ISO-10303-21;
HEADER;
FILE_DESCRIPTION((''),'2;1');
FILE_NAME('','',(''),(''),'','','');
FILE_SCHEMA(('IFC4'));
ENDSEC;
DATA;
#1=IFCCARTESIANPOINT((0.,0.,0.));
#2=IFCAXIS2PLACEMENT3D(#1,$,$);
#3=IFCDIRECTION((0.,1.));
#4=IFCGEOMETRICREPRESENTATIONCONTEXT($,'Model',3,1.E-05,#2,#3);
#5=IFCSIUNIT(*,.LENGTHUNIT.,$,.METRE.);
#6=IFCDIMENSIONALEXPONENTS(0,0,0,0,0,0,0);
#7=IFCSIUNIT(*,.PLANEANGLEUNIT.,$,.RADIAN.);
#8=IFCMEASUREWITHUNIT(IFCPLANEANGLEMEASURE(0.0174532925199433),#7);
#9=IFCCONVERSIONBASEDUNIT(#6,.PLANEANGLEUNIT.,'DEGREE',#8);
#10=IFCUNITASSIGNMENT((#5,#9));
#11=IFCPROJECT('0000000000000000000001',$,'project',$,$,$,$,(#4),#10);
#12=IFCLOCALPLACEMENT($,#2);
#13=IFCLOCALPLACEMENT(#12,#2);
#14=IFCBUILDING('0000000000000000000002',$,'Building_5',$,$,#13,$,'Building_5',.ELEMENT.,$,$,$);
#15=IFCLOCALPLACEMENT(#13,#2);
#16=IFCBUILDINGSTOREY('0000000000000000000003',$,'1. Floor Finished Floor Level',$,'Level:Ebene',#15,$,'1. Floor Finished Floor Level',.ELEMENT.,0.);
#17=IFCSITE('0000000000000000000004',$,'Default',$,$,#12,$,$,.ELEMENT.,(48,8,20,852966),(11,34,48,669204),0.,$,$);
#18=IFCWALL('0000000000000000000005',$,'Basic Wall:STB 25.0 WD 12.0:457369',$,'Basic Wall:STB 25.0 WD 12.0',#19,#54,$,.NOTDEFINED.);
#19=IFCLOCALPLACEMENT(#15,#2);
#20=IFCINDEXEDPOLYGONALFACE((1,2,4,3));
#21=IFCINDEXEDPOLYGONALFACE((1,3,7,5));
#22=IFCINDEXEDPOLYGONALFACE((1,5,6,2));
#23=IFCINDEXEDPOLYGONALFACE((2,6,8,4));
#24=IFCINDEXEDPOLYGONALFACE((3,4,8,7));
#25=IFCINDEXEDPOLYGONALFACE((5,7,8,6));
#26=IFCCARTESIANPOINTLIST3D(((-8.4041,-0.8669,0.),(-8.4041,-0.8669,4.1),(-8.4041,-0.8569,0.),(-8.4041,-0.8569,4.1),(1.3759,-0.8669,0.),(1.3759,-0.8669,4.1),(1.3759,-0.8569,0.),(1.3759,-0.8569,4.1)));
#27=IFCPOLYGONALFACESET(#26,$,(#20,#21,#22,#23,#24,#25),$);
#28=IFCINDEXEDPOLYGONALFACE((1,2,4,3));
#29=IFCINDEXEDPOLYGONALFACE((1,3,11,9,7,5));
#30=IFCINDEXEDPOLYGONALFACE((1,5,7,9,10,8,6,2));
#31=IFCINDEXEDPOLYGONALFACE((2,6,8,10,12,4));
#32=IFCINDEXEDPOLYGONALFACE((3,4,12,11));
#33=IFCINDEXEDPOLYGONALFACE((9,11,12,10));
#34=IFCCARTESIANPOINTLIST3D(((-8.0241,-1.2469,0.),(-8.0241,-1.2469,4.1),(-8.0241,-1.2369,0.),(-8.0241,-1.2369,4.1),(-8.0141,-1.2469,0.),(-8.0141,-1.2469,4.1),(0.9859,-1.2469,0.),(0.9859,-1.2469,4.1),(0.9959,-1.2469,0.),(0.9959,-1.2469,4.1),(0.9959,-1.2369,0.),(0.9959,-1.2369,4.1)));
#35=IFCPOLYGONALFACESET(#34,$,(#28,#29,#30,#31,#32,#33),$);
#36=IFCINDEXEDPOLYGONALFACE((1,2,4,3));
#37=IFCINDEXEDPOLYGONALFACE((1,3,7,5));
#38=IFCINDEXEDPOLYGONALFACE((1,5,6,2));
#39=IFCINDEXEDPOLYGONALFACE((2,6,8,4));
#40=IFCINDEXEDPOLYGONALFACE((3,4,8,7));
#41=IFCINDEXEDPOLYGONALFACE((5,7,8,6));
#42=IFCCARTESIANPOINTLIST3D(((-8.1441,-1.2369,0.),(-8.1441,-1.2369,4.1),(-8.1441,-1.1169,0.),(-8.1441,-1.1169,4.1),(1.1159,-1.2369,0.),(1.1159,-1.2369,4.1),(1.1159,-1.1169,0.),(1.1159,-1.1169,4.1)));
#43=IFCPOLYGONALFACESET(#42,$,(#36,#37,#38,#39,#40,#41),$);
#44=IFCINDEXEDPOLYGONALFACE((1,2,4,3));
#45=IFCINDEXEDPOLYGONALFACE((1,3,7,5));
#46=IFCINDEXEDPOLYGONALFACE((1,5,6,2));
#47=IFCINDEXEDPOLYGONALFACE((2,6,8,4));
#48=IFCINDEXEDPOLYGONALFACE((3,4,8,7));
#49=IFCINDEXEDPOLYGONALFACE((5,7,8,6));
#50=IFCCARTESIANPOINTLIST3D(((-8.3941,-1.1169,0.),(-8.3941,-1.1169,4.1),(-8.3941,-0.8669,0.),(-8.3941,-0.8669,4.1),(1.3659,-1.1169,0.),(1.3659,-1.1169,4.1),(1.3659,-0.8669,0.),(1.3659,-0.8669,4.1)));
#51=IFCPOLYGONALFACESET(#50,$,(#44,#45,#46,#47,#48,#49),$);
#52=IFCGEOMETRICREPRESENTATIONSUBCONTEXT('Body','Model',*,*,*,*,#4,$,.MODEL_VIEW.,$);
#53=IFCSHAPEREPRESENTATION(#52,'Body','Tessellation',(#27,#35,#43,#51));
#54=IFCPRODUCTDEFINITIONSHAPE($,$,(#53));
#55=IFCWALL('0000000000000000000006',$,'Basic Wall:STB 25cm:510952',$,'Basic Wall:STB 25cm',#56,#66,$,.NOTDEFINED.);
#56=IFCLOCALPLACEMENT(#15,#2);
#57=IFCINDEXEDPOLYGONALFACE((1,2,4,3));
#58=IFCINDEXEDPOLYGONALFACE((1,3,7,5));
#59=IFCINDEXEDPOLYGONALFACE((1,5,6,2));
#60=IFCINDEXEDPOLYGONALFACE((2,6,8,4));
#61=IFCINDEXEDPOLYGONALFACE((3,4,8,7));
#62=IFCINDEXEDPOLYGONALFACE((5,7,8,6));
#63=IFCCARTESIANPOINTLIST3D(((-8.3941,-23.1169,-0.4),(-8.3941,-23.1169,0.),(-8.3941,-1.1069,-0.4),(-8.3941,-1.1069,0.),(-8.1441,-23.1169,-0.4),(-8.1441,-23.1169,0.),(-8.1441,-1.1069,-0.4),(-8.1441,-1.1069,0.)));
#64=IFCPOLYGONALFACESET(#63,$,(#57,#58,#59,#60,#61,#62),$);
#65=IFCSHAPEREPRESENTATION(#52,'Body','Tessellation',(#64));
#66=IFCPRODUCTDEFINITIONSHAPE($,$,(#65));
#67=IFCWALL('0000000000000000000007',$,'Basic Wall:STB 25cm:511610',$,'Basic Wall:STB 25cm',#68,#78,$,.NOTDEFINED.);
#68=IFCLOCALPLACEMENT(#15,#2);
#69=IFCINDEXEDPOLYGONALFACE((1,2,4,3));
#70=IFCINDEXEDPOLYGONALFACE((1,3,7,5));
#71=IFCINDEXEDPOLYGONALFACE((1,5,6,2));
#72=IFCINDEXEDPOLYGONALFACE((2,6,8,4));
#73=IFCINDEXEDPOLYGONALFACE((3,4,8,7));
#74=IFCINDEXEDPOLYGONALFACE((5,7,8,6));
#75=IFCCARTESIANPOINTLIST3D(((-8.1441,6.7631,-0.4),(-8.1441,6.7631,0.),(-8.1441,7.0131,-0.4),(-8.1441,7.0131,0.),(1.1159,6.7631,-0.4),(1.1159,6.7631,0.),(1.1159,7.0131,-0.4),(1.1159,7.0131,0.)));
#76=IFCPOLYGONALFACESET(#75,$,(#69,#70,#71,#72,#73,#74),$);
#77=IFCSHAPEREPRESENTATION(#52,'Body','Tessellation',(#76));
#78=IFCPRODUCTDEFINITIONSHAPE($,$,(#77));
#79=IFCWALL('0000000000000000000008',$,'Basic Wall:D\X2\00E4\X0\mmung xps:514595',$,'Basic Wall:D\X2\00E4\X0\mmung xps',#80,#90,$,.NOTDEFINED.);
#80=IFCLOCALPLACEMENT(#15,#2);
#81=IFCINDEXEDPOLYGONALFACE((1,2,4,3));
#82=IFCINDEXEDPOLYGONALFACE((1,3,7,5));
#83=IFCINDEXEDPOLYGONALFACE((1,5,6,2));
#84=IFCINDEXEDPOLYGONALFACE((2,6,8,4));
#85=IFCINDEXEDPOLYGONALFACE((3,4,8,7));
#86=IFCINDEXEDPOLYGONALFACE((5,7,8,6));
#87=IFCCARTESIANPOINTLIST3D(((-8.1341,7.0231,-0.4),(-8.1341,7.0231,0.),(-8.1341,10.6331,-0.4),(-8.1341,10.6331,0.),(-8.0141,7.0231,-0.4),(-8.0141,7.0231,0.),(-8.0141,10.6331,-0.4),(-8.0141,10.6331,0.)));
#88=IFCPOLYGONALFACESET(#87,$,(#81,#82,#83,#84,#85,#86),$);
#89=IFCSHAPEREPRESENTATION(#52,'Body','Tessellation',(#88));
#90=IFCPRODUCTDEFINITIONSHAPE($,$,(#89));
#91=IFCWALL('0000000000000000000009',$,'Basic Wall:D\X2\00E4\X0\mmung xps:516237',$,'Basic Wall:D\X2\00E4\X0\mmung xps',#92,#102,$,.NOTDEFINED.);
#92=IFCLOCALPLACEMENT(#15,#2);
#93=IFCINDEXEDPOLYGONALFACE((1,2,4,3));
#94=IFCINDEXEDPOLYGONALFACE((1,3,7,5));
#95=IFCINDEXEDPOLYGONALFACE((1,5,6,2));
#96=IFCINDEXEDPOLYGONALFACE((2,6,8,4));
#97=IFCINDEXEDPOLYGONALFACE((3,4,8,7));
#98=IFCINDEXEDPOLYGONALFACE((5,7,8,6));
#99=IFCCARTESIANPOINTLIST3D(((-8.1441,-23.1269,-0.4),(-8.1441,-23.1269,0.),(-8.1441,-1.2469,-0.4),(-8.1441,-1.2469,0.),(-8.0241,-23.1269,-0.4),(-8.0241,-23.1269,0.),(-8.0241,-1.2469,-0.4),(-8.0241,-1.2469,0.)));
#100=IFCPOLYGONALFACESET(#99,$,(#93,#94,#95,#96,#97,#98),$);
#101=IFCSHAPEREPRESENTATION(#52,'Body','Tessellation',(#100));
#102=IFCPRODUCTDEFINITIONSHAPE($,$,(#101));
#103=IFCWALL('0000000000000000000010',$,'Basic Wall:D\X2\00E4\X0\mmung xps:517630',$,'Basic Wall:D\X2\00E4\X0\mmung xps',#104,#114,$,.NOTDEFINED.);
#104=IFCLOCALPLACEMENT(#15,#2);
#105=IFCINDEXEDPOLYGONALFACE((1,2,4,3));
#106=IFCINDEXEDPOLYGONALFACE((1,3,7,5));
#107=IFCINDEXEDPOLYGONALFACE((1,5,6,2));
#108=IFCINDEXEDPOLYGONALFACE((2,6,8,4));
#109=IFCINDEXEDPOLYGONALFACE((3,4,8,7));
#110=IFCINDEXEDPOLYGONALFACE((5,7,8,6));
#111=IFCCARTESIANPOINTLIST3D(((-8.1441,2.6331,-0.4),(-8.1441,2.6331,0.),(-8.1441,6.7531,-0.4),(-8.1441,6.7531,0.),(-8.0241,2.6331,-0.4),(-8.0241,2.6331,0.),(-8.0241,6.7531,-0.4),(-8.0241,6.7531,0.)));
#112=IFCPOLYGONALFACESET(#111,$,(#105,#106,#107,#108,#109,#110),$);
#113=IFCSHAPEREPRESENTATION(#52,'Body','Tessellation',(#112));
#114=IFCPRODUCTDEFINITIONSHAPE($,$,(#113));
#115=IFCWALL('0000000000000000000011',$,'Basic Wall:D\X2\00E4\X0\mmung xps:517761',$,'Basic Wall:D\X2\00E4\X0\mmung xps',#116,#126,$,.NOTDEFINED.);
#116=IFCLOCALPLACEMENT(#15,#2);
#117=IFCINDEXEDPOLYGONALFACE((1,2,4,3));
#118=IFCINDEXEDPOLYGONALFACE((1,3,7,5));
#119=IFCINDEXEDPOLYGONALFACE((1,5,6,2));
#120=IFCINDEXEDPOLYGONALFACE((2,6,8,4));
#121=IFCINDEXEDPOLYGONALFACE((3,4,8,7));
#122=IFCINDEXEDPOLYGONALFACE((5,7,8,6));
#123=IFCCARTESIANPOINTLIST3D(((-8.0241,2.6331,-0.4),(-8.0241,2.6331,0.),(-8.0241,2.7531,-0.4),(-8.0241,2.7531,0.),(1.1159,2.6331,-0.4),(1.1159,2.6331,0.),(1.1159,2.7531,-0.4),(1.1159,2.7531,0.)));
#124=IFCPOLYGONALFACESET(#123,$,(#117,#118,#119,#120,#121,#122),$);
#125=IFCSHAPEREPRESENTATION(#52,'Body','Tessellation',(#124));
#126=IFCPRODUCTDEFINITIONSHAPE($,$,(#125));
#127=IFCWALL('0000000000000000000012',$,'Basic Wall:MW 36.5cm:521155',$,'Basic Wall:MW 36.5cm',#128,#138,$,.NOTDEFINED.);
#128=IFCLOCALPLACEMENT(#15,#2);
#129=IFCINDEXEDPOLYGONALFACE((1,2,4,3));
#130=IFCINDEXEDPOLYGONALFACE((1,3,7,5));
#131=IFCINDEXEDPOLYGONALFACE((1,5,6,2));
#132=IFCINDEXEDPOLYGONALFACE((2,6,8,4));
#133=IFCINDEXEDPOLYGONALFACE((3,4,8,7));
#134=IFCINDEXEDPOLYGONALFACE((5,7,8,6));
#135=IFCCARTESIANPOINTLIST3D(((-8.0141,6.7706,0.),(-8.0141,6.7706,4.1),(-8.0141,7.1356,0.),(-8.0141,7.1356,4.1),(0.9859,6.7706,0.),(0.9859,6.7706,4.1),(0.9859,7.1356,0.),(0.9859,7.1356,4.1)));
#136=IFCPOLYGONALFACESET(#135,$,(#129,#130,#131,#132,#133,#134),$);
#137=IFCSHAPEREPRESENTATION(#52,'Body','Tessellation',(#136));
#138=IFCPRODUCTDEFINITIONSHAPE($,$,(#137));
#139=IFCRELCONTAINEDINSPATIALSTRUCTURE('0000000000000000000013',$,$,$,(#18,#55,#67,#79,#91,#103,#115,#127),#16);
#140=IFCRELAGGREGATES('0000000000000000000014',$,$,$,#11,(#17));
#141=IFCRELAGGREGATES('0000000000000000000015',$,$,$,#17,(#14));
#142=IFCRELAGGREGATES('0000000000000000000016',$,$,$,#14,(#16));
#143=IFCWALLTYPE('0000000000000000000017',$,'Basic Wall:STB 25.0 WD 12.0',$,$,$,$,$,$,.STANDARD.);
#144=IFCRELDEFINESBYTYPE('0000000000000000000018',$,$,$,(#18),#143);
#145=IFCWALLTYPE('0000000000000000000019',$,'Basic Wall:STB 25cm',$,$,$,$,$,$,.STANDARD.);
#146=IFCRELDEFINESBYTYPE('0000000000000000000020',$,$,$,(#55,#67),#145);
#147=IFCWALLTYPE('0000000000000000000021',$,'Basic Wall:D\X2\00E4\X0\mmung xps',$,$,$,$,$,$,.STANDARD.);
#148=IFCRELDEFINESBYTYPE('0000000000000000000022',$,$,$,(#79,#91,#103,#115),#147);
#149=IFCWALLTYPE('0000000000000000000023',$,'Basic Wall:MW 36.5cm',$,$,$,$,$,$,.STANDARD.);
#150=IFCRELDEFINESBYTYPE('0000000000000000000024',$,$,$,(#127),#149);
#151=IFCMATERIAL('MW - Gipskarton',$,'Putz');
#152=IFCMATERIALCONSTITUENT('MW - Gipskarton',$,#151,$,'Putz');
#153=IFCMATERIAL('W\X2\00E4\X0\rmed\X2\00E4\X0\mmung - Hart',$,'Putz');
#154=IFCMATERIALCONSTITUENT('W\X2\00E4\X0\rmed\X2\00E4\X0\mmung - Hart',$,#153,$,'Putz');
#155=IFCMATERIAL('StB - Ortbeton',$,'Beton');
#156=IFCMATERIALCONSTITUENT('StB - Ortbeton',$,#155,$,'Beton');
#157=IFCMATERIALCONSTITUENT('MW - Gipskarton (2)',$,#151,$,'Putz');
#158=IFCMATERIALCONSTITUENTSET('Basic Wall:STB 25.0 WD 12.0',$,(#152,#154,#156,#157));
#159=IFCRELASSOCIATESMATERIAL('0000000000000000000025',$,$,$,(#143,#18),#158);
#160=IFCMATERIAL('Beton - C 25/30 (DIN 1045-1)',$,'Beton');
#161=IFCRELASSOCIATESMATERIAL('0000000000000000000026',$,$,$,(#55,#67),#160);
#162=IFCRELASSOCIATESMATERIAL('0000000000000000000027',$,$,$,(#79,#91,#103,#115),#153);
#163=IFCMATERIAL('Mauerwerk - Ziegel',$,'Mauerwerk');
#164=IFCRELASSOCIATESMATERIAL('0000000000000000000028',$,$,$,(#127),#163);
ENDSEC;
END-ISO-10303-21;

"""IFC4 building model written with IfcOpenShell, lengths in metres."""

from ifc_helpers import new_model, entity, si_unit, converted_unit, direction, frame, origin, place, context, subcontext, project, spatial, indexed_curve, outline, extrude, material, constituent, constituent_set, type_object, element, save


model = new_model("IFC4")

# Units and contexts
model_context = context("Model", 3, precision=1e-05, world=origin(), true_north=direction((0.0, 1.0)))
body_context = subcontext(model_context, "Body", "Model", "MODEL_VIEW")
ifc_project = project(units=[si_unit("LENGTHUNIT", "METRE"), converted_unit("PLANEANGLEUNIT", "DEGREE", entity("IfcPlaneAngleMeasure", 0.0174532925199433), si_unit("PLANEANGLEUNIT", "RADIAN"), dimensions=[0, 0, 0, 0, 0, 0, 0])], contexts=[model_context])

# Site, building, storey
site_placement = place(None, origin())
site = spatial("IfcSite", under=ifc_project, at=site_placement, Name="Default", CompositionType="ELEMENT", RefLatitude=(48, 8, 20, 852966), RefLongitude=(11, 34, 48, 669204), RefElevation=0.0)
building_placement = place(site_placement, origin())
building = spatial("IfcBuilding", under=site, at=building_placement, Name="Building_5", LongName="Building_5", CompositionType="ELEMENT")
storey_placement = place(building_placement, origin())
storey = spatial("IfcBuildingStorey", under=building, at=storey_placement, Name="1. Floor Finished Floor Level", ObjectType="Level:Ebene", LongName="1. Floor Finished Floor Level", CompositionType="ELEMENT", Elevation=0.0)

# Shared definitions
ifc_material_1 = material(Name="Mauerwerk - Ziegel", Category="Mauerwerk")

# Wall
ifc_material_2 = material(Name="MW - Gipskarton", Category="Putz")
ifc_constituent_1 = constituent(ifc_material_2, Name="MW - Gipskarton", Category="Putz")
ifc_material_3 = material(Name="Wärmedämmung - Hart", Category="Putz")
ifc_constituent_2 = constituent(ifc_material_3, Name="Wärmedämmung - Hart", Category="Putz")
ifc_material_4 = material(Name="StB - Ortbeton", Category="Beton")
ifc_constituent_3 = constituent(ifc_material_4, Name="StB - Ortbeton", Category="Beton")
ifc_constituent_4 = constituent(ifc_material_2, Name="MW - Gipskarton (2)", Category="Putz")
ifc_constituent_set_1 = constituent_set(constituents=[ifc_constituent_1, ifc_constituent_2, ifc_constituent_3, ifc_constituent_4], Name="Basic Wall:STB 25.0 WD 12.0")
wall_type_1 = type_object("IfcWallType", Name="Basic Wall:STB 25.0 WD 12.0", PredefinedType="STANDARD", material=ifc_constituent_set_1)
wall_1_placement = place(storey_placement, frame((-8.4041, -1.0519, 0.0)))
element("IfcWall", 1, at=wall_1_placement, inside=storey, type_object=wall_type_1, material=ifc_constituent_set_1, Name="Basic Wall:STB 25.0 WD 12.0:457369", ObjectType="Basic Wall:STB 25.0 WD 12.0", PredefinedType="NOTDEFINED", context=body_context, shape_type="SweptSolid", body=[
    extrude(outline(indexed_curve([(-0.005, -4.89), (0.005, -4.89), (0.005, 4.89), (-0.005, 4.89), (-0.005, -4.89)], self_intersect=False)), frame((4.89, 0.19, 0.0), z_axis=(0.0, 0.0, 1.0), x_axis=(0.0, -1.0, 0.0)), (0.0, 0.0, 1.0), 4.1),
    extrude(outline(indexed_curve([(-4.5, -0.0033), (4.5, -0.0033), (4.51, -0.0033), (4.51, 0.0067), (-4.51, 0.0067), (-4.51, -0.0033), (-4.5, -0.0033)], self_intersect=False)), frame((4.89, -0.1917, 0.0)), (0.0, 0.0, 1.0), 4.1),
    extrude(outline(indexed_curve([(-4.63, -0.06), (4.63, -0.06), (4.63, 0.06), (-4.63, 0.06), (-4.63, -0.06)], self_intersect=False)), frame((4.89, -0.125, 0.0)), (0.0, 0.0, 1.0), 4.1),
    extrude(outline(indexed_curve([(-4.88, -0.125), (4.88, -0.125), (4.88, 0.125), (-4.88, 0.125), (-4.88, -0.125)], self_intersect=False)), frame((4.89, 0.06, 0.0)), (0.0, 0.0, 1.0), 4.1),
])

# Walls
ifc_material_5 = material(Name="Beton - C 25/30 (DIN 1045-1)", Category="Beton")
wall_type_2 = type_object("IfcWallType", Name="Basic Wall:STB 25cm", PredefinedType="STANDARD")
wall_2_placement = place(storey_placement, frame((-8.2691, -1.1069, -0.4), z_axis=(0.0, 0.0, 1.0), x_axis=(0.0, -1.0, 0.0)))
element("IfcWall", 2, at=wall_2_placement, inside=storey, type_object=wall_type_2, material=ifc_material_5, Name="Basic Wall:STB 25cm:510952", ObjectType="Basic Wall:STB 25cm", PredefinedType="NOTDEFINED", context=body_context, shape_type="SweptSolid", body=[
    extrude(outline(indexed_curve([(22.01, 0.125), (0.0, 0.125), (0.0, -0.125), (22.01, -0.125), (22.01, 0.125)], self_intersect=False)), origin(), (0.0, 0.0, 1.0), 0.4),
])
wall_3_placement = place(storey_placement, frame((-8.1441, 6.8881, -0.4)))
element("IfcWall", 3, at=wall_3_placement, inside=storey, type_object=wall_type_2, material=ifc_material_5, Name="Basic Wall:STB 25cm:511610", ObjectType="Basic Wall:STB 25cm", PredefinedType="NOTDEFINED", context=body_context, shape_type="SweptSolid", body=[
    extrude(outline(indexed_curve([(9.26, 0.125), (0.0, 0.125), (0.0, -0.125), (9.26, -0.125), (9.26, 0.125)], self_intersect=False)), origin(), (0.0, 0.0, 1.0), 0.4),
])
wall_type_3 = type_object("IfcWallType", Name="Basic Wall:Dämmung xps", PredefinedType="STANDARD")
wall_4_placement = place(storey_placement, frame((-8.0741, 10.6331, -0.4), z_axis=(0.0, 0.0, 1.0), x_axis=(0.0, -1.0, 0.0)))
element("IfcWall", 4, at=wall_4_placement, inside=storey, type_object=wall_type_3, material=ifc_material_3, Name="Basic Wall:Dämmung xps:514595", ObjectType="Basic Wall:Dämmung xps", PredefinedType="NOTDEFINED", context=body_context, shape_type="SweptSolid", body=[
    extrude(outline(indexed_curve([(3.61, 0.06), (0.0, 0.06), (0.0, -0.06), (3.61, -0.06), (3.61, 0.06)], self_intersect=False)), origin(), (0.0, 0.0, 1.0), 0.4),
])
wall_5_placement = place(storey_placement, frame((-8.0841, -1.2469, -0.4), z_axis=(0.0, 0.0, 1.0), x_axis=(0.0, -1.0, 0.0)))
element("IfcWall", 5, at=wall_5_placement, inside=storey, type_object=wall_type_3, material=ifc_material_3, Name="Basic Wall:Dämmung xps:516237", ObjectType="Basic Wall:Dämmung xps", PredefinedType="NOTDEFINED", context=body_context, shape_type="SweptSolid", body=[
    extrude(outline(indexed_curve([(21.88, 0.06), (0.0, 0.06), (0.0, -0.06), (21.88, -0.06), (21.88, 0.06)], self_intersect=False)), origin(), (0.0, 0.0, 1.0), 0.4),
])
wall_6_placement = place(storey_placement, frame((-8.0841, 6.7531, -0.4), z_axis=(0.0, 0.0, 1.0), x_axis=(0.0, -1.0, 0.0)))
element("IfcWall", 6, at=wall_6_placement, inside=storey, type_object=wall_type_3, material=ifc_material_3, Name="Basic Wall:Dämmung xps:517630", ObjectType="Basic Wall:Dämmung xps", PredefinedType="NOTDEFINED", context=body_context, shape_type="SweptSolid", body=[
    extrude(outline(indexed_curve([(4.12, 0.06), (0.0, 0.06), (0.0, -0.06), (4.12, -0.06), (4.12, 0.06)], self_intersect=False)), origin(), (0.0, 0.0, 1.0), 0.4),
])
wall_7_placement = place(storey_placement, frame((-8.0241, 2.6931, -0.4)))
element("IfcWall", 7, at=wall_7_placement, inside=storey, type_object=wall_type_3, material=ifc_material_3, Name="Basic Wall:Dämmung xps:517761", ObjectType="Basic Wall:Dämmung xps", PredefinedType="NOTDEFINED", context=body_context, shape_type="SweptSolid", body=[
    extrude(outline(indexed_curve([(9.14, 0.06), (0.0, 0.06), (0.0, -0.06), (9.14, -0.06), (9.14, 0.06)], self_intersect=False)), origin(), (0.0, 0.0, 1.0), 0.4),
])
wall_type_4 = type_object("IfcWallType", Name="Basic Wall:MW 36.5cm", PredefinedType="STANDARD")
wall_8_placement = place(storey_placement, frame((-8.0141, 6.9531, 0.0)))
element("IfcWall", 8, at=wall_8_placement, inside=storey, type_object=wall_type_4, material=ifc_material_1, Name="Basic Wall:MW 36.5cm:521155", ObjectType="Basic Wall:MW 36.5cm", PredefinedType="NOTDEFINED", context=body_context, shape_type="SweptSolid", body=[
    extrude(outline(indexed_curve([(9.0, 0.1825), (0.0, 0.1825), (0.0, -0.1825), (9.0, -0.1825), (9.0, 0.1825)], self_intersect=False)), origin(), (0.0, 0.0, 1.0), 4.1),
])

save(model, "model.ifc")
